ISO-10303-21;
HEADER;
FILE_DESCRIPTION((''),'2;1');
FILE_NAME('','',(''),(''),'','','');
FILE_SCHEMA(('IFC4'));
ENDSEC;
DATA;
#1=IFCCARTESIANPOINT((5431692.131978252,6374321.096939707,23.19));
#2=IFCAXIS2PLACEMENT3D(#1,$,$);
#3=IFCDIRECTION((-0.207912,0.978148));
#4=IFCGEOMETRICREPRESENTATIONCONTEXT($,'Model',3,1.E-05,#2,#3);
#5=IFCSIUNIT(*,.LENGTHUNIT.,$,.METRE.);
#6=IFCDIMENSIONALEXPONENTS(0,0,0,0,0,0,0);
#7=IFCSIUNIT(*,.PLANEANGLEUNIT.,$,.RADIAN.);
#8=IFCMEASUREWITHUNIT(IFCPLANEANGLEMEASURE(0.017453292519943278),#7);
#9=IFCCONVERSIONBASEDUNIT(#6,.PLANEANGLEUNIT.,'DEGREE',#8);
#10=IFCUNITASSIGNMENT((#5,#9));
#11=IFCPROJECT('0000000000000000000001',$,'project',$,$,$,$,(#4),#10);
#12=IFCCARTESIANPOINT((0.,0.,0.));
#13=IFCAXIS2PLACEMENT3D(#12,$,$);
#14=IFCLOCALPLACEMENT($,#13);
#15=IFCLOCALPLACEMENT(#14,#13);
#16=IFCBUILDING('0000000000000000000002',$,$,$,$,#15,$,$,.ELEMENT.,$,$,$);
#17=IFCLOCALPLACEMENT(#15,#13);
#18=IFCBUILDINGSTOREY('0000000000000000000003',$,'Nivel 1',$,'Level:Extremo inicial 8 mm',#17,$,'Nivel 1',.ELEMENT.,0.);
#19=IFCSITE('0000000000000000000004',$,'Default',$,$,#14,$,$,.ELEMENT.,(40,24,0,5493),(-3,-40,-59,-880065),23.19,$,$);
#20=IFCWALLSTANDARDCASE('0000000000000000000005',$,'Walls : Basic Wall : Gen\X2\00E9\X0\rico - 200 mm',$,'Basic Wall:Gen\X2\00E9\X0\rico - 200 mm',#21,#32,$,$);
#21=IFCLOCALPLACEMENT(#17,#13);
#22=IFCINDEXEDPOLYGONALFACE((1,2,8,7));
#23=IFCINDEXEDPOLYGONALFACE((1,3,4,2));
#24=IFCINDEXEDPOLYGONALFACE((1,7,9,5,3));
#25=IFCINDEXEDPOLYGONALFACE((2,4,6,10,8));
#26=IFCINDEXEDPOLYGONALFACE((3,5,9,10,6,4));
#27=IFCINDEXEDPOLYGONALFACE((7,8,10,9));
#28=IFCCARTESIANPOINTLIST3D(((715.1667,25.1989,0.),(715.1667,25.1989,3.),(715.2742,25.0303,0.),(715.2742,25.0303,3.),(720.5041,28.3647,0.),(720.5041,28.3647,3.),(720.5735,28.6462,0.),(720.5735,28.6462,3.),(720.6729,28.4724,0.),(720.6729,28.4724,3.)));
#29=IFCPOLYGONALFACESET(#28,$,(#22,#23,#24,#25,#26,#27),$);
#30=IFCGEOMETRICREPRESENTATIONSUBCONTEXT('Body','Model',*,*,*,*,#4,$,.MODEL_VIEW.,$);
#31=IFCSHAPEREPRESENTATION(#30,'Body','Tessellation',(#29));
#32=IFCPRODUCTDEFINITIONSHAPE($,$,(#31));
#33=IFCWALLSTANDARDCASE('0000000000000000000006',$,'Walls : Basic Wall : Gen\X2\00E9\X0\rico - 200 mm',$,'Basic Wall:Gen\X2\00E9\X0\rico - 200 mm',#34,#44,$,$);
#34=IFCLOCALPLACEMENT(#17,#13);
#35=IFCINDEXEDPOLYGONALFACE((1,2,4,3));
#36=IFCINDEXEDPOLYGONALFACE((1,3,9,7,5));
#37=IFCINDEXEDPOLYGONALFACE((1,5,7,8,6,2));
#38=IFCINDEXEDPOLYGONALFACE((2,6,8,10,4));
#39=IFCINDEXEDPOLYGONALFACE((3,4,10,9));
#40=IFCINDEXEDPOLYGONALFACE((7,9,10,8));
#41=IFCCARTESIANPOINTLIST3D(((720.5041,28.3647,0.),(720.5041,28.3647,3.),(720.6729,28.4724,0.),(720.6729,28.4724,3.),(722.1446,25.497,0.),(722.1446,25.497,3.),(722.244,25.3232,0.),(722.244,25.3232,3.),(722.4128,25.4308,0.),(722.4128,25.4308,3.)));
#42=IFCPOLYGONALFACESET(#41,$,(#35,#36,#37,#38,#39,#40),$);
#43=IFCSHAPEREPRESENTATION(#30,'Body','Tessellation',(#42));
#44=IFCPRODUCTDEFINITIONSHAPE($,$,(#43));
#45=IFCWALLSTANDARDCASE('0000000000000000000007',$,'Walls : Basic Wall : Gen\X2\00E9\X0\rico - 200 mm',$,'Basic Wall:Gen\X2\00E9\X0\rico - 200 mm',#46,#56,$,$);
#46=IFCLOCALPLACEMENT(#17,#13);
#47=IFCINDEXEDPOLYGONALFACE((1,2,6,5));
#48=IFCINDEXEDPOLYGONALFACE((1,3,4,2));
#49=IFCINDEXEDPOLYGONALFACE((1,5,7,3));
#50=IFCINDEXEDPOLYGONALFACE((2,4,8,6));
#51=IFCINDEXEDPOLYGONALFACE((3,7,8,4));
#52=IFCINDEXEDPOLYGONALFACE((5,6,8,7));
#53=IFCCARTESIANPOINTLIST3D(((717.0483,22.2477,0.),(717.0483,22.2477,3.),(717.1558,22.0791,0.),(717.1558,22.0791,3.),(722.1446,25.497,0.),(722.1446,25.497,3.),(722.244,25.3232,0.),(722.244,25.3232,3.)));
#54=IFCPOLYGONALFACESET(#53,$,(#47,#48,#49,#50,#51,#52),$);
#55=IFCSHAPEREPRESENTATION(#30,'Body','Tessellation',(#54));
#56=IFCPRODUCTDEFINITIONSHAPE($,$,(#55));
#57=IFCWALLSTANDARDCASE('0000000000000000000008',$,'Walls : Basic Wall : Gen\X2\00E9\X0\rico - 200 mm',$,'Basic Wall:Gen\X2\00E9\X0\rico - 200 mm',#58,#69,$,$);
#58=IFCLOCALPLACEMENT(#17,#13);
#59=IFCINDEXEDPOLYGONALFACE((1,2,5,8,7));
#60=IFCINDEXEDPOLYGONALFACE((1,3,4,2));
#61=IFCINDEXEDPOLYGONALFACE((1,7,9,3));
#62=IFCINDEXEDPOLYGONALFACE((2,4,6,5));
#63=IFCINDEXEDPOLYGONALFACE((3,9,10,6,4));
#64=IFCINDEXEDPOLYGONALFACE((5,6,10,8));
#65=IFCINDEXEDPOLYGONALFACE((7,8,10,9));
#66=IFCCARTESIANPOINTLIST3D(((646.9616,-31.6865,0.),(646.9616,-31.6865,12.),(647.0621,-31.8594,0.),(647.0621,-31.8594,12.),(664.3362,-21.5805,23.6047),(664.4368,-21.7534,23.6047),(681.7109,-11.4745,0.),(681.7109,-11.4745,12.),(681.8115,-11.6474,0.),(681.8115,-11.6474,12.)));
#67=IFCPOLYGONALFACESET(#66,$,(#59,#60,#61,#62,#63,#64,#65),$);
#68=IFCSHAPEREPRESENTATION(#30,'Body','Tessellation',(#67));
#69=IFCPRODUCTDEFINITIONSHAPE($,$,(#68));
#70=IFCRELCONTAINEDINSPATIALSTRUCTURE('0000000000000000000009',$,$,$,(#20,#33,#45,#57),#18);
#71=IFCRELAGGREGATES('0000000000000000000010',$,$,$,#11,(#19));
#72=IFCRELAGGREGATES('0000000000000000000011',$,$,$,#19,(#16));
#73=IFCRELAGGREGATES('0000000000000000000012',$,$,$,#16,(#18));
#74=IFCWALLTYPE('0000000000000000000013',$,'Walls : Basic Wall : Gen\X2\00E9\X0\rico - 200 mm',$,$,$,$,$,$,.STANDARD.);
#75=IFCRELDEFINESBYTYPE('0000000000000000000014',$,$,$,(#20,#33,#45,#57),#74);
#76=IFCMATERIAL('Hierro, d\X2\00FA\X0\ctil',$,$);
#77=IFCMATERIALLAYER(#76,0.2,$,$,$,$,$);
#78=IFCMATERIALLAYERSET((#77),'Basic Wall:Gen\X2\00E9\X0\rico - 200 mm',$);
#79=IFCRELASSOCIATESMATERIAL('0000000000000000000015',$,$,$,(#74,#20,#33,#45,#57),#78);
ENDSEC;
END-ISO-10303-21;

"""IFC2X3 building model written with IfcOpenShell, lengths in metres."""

from ifc_helpers import new_model, entity, si_unit, converted_unit, direction, frame, frame_2d, origin, place, context, subcontext, project, spatial, polyline, rectangle, outline, extrude, clip, bounded_halfspace, material, layer, layer_set, layer_usage, type_object, element, save


model = new_model("IFC2X3")

# Units and contexts
model_context = context("Model", 3, precision=1e-05, world=frame((5431692.131978252, 6374321.096939707, 23.19)), true_north=direction((-0.207912, 0.978148)))
body_context = subcontext(model_context, "Body", "Model", "MODEL_VIEW")
ifc_project = project(units=[si_unit("LENGTHUNIT", "METRE"), converted_unit("PLANEANGLEUNIT", "DEGREE", entity("IfcPlaneAngleMeasure", 0.017453292519943278), si_unit("PLANEANGLEUNIT", "RADIAN"), dimensions=[0, 0, 0, 0, 0, 0, 0])], contexts=[model_context])

# Site, building, storey
site_placement = place(None, origin())
site = spatial("IfcSite", under=ifc_project, at=site_placement, Name="Default", CompositionType="ELEMENT", RefLatitude=(40, 24, 0, 5493), RefLongitude=(-3, -40, -59, -880065), RefElevation=23.19)
building_placement = place(site_placement, origin())
building = spatial("IfcBuilding", under=site, at=building_placement, CompositionType="ELEMENT")
storey_placement = place(building_placement, origin())
storey = spatial("IfcBuildingStorey", under=building, at=storey_placement, Name="Nivel 1", ObjectType="Level:Extremo inicial 8 mm", LongName="Nivel 1", CompositionType="ELEMENT", Elevation=0.0)

# Walls
ifc_material_1 = material(Name="Hierro, dúctil")
ifc_layer_1 = layer(ifc_material_1, 0.2)
ifc_layer_set_1 = layer_set([ifc_layer_1], Name="Basic Wall:Genérico - 200 mm")
wall_type = type_object("IfcWallType", Name="Walls : Basic Wall : Genérico - 200 mm", PredefinedType="STANDARD", material=ifc_layer_set_1)
ifc_layer_usage_1 = layer_usage(ifc_layer_set_1, "AXIS2", "NEGATIVE", 0.1)
wall_1_placement = place(storey_placement, frame((715.2205, 25.1146, 0.0), z_axis=(0.0, 0.0, 1.0), x_axis=(0.843195, 0.537608, 0.0)))
element("IfcWallStandardCase", 1, at=wall_1_placement, inside=storey, type_object=wall_type, material=ifc_layer_usage_1, Name="Walls : Basic Wall : Genérico - 200 mm", ObjectType="Basic Wall:Genérico - 200 mm", context=body_context, shape_type="SweptSolid", body=[
    extrude(outline(polyline([(6.4027, -0.1), (6.4123, 0.1), (0.0, 0.1), (0.0, -0.1), (6.2025, -0.1), (6.4027, -0.1)])), origin(), (0.0, 0.0, 1.0), 3.0),
])
ifc_layer_usage_2 = layer_usage(ifc_layer_set_1, "AXIS2", "NEGATIVE", 0.1)
wall_2_placement = place(storey_placement, frame((720.5861, 28.4227, 0.0), z_axis=(0.0, 0.0, 1.0), x_axis=(0.496542, -0.868013, 0.0)))
element("IfcWallStandardCase", 2, at=wall_2_placement, inside=storey, type_object=wall_type, material=ifc_layer_usage_2, Name="Walls : Basic Wall : Genérico - 200 mm", ObjectType="Basic Wall:Genérico - 200 mm", context=body_context, shape_type="SweptSolid", body=[
    extrude(outline(polyline([(3.5136, -0.1), (3.504, 0.1), (0.0, 0.1), (0.0096, -0.1), (3.3134, -0.1), (3.5136, -0.1)])), origin(), (0.0, 0.0, 1.0), 3.0),
])
ifc_layer_usage_3 = layer_usage(ifc_layer_set_1, "AXIS2", "NEGATIVE", 0.1)
wall_3_placement = place(storey_placement, frame((722.1983, 25.4127, 0.0), z_axis=(0.0, 0.0, 1.0), x_axis=(-0.843195, -0.537608, 0.0)))
element("IfcWallStandardCase", 3, at=wall_3_placement, inside=storey, type_object=wall_type, material=ifc_layer_usage_3, Name="Walls : Basic Wall : Genérico - 200 mm", ObjectType="Basic Wall:Genérico - 200 mm", context=body_context, shape_type="SweptSolid", body=[
    extrude(outline(polyline([(6.044, -0.1), (6.044, 0.1), (0.0096, 0.1), (0.0, -0.1), (6.044, -0.1)])), origin(), (0.0, 0.0, 1.0), 3.0),
])
ifc_layer_usage_4 = layer_usage(ifc_layer_set_1, "AXIS2", "NEGATIVE", 0.1)
wall_4_placement = place(storey_placement, frame((647.0118, -31.7729, 0.0), z_axis=(0.0, 0.0, 1.0), x_axis=(0.864412, 0.502785, 0.0)))
element("IfcWallStandardCase", 4, at=wall_4_placement, inside=storey, type_object=wall_type, material=ifc_layer_usage_4, Name="Walls : Basic Wall : Genérico - 200 mm", ObjectType="Basic Wall:Genérico - 200 mm", context=body_context, shape_type="Clipping", body=[
    clip(clip(extrude(rectangle(XDim=40.2, YDim=0.2, at=frame_2d((20.1, 0.0), x_axis=(-1.0, 0.0))), origin(), (0.0, 0.0, 1.0), 23.6047), bounded_halfspace(frame((20.1, -0.1, 23.6047), z_axis=(0.5, 0.0, 0.866025), x_axis=(0.0, 1.0, 0.0)), False, frame((20.1, -0.1, 23.6047)), polyline([(0.0, 0.0), (20.1, 0.0), (20.1, 0.2), (0.0, 0.2), (0.0, 0.0)]))), bounded_halfspace(frame((0.0, -0.1, 12.0), z_axis=(-0.5, 0.0, 0.866025), x_axis=(0.0, -1.0, 0.0)), False, frame((0.0, -0.1, 12.0)), polyline([(0.0, 0.0), (20.1, 0.0), (20.1, 0.2), (0.0, 0.2), (0.0, 0.0)]))),
])

save(model, "model.ifc")
